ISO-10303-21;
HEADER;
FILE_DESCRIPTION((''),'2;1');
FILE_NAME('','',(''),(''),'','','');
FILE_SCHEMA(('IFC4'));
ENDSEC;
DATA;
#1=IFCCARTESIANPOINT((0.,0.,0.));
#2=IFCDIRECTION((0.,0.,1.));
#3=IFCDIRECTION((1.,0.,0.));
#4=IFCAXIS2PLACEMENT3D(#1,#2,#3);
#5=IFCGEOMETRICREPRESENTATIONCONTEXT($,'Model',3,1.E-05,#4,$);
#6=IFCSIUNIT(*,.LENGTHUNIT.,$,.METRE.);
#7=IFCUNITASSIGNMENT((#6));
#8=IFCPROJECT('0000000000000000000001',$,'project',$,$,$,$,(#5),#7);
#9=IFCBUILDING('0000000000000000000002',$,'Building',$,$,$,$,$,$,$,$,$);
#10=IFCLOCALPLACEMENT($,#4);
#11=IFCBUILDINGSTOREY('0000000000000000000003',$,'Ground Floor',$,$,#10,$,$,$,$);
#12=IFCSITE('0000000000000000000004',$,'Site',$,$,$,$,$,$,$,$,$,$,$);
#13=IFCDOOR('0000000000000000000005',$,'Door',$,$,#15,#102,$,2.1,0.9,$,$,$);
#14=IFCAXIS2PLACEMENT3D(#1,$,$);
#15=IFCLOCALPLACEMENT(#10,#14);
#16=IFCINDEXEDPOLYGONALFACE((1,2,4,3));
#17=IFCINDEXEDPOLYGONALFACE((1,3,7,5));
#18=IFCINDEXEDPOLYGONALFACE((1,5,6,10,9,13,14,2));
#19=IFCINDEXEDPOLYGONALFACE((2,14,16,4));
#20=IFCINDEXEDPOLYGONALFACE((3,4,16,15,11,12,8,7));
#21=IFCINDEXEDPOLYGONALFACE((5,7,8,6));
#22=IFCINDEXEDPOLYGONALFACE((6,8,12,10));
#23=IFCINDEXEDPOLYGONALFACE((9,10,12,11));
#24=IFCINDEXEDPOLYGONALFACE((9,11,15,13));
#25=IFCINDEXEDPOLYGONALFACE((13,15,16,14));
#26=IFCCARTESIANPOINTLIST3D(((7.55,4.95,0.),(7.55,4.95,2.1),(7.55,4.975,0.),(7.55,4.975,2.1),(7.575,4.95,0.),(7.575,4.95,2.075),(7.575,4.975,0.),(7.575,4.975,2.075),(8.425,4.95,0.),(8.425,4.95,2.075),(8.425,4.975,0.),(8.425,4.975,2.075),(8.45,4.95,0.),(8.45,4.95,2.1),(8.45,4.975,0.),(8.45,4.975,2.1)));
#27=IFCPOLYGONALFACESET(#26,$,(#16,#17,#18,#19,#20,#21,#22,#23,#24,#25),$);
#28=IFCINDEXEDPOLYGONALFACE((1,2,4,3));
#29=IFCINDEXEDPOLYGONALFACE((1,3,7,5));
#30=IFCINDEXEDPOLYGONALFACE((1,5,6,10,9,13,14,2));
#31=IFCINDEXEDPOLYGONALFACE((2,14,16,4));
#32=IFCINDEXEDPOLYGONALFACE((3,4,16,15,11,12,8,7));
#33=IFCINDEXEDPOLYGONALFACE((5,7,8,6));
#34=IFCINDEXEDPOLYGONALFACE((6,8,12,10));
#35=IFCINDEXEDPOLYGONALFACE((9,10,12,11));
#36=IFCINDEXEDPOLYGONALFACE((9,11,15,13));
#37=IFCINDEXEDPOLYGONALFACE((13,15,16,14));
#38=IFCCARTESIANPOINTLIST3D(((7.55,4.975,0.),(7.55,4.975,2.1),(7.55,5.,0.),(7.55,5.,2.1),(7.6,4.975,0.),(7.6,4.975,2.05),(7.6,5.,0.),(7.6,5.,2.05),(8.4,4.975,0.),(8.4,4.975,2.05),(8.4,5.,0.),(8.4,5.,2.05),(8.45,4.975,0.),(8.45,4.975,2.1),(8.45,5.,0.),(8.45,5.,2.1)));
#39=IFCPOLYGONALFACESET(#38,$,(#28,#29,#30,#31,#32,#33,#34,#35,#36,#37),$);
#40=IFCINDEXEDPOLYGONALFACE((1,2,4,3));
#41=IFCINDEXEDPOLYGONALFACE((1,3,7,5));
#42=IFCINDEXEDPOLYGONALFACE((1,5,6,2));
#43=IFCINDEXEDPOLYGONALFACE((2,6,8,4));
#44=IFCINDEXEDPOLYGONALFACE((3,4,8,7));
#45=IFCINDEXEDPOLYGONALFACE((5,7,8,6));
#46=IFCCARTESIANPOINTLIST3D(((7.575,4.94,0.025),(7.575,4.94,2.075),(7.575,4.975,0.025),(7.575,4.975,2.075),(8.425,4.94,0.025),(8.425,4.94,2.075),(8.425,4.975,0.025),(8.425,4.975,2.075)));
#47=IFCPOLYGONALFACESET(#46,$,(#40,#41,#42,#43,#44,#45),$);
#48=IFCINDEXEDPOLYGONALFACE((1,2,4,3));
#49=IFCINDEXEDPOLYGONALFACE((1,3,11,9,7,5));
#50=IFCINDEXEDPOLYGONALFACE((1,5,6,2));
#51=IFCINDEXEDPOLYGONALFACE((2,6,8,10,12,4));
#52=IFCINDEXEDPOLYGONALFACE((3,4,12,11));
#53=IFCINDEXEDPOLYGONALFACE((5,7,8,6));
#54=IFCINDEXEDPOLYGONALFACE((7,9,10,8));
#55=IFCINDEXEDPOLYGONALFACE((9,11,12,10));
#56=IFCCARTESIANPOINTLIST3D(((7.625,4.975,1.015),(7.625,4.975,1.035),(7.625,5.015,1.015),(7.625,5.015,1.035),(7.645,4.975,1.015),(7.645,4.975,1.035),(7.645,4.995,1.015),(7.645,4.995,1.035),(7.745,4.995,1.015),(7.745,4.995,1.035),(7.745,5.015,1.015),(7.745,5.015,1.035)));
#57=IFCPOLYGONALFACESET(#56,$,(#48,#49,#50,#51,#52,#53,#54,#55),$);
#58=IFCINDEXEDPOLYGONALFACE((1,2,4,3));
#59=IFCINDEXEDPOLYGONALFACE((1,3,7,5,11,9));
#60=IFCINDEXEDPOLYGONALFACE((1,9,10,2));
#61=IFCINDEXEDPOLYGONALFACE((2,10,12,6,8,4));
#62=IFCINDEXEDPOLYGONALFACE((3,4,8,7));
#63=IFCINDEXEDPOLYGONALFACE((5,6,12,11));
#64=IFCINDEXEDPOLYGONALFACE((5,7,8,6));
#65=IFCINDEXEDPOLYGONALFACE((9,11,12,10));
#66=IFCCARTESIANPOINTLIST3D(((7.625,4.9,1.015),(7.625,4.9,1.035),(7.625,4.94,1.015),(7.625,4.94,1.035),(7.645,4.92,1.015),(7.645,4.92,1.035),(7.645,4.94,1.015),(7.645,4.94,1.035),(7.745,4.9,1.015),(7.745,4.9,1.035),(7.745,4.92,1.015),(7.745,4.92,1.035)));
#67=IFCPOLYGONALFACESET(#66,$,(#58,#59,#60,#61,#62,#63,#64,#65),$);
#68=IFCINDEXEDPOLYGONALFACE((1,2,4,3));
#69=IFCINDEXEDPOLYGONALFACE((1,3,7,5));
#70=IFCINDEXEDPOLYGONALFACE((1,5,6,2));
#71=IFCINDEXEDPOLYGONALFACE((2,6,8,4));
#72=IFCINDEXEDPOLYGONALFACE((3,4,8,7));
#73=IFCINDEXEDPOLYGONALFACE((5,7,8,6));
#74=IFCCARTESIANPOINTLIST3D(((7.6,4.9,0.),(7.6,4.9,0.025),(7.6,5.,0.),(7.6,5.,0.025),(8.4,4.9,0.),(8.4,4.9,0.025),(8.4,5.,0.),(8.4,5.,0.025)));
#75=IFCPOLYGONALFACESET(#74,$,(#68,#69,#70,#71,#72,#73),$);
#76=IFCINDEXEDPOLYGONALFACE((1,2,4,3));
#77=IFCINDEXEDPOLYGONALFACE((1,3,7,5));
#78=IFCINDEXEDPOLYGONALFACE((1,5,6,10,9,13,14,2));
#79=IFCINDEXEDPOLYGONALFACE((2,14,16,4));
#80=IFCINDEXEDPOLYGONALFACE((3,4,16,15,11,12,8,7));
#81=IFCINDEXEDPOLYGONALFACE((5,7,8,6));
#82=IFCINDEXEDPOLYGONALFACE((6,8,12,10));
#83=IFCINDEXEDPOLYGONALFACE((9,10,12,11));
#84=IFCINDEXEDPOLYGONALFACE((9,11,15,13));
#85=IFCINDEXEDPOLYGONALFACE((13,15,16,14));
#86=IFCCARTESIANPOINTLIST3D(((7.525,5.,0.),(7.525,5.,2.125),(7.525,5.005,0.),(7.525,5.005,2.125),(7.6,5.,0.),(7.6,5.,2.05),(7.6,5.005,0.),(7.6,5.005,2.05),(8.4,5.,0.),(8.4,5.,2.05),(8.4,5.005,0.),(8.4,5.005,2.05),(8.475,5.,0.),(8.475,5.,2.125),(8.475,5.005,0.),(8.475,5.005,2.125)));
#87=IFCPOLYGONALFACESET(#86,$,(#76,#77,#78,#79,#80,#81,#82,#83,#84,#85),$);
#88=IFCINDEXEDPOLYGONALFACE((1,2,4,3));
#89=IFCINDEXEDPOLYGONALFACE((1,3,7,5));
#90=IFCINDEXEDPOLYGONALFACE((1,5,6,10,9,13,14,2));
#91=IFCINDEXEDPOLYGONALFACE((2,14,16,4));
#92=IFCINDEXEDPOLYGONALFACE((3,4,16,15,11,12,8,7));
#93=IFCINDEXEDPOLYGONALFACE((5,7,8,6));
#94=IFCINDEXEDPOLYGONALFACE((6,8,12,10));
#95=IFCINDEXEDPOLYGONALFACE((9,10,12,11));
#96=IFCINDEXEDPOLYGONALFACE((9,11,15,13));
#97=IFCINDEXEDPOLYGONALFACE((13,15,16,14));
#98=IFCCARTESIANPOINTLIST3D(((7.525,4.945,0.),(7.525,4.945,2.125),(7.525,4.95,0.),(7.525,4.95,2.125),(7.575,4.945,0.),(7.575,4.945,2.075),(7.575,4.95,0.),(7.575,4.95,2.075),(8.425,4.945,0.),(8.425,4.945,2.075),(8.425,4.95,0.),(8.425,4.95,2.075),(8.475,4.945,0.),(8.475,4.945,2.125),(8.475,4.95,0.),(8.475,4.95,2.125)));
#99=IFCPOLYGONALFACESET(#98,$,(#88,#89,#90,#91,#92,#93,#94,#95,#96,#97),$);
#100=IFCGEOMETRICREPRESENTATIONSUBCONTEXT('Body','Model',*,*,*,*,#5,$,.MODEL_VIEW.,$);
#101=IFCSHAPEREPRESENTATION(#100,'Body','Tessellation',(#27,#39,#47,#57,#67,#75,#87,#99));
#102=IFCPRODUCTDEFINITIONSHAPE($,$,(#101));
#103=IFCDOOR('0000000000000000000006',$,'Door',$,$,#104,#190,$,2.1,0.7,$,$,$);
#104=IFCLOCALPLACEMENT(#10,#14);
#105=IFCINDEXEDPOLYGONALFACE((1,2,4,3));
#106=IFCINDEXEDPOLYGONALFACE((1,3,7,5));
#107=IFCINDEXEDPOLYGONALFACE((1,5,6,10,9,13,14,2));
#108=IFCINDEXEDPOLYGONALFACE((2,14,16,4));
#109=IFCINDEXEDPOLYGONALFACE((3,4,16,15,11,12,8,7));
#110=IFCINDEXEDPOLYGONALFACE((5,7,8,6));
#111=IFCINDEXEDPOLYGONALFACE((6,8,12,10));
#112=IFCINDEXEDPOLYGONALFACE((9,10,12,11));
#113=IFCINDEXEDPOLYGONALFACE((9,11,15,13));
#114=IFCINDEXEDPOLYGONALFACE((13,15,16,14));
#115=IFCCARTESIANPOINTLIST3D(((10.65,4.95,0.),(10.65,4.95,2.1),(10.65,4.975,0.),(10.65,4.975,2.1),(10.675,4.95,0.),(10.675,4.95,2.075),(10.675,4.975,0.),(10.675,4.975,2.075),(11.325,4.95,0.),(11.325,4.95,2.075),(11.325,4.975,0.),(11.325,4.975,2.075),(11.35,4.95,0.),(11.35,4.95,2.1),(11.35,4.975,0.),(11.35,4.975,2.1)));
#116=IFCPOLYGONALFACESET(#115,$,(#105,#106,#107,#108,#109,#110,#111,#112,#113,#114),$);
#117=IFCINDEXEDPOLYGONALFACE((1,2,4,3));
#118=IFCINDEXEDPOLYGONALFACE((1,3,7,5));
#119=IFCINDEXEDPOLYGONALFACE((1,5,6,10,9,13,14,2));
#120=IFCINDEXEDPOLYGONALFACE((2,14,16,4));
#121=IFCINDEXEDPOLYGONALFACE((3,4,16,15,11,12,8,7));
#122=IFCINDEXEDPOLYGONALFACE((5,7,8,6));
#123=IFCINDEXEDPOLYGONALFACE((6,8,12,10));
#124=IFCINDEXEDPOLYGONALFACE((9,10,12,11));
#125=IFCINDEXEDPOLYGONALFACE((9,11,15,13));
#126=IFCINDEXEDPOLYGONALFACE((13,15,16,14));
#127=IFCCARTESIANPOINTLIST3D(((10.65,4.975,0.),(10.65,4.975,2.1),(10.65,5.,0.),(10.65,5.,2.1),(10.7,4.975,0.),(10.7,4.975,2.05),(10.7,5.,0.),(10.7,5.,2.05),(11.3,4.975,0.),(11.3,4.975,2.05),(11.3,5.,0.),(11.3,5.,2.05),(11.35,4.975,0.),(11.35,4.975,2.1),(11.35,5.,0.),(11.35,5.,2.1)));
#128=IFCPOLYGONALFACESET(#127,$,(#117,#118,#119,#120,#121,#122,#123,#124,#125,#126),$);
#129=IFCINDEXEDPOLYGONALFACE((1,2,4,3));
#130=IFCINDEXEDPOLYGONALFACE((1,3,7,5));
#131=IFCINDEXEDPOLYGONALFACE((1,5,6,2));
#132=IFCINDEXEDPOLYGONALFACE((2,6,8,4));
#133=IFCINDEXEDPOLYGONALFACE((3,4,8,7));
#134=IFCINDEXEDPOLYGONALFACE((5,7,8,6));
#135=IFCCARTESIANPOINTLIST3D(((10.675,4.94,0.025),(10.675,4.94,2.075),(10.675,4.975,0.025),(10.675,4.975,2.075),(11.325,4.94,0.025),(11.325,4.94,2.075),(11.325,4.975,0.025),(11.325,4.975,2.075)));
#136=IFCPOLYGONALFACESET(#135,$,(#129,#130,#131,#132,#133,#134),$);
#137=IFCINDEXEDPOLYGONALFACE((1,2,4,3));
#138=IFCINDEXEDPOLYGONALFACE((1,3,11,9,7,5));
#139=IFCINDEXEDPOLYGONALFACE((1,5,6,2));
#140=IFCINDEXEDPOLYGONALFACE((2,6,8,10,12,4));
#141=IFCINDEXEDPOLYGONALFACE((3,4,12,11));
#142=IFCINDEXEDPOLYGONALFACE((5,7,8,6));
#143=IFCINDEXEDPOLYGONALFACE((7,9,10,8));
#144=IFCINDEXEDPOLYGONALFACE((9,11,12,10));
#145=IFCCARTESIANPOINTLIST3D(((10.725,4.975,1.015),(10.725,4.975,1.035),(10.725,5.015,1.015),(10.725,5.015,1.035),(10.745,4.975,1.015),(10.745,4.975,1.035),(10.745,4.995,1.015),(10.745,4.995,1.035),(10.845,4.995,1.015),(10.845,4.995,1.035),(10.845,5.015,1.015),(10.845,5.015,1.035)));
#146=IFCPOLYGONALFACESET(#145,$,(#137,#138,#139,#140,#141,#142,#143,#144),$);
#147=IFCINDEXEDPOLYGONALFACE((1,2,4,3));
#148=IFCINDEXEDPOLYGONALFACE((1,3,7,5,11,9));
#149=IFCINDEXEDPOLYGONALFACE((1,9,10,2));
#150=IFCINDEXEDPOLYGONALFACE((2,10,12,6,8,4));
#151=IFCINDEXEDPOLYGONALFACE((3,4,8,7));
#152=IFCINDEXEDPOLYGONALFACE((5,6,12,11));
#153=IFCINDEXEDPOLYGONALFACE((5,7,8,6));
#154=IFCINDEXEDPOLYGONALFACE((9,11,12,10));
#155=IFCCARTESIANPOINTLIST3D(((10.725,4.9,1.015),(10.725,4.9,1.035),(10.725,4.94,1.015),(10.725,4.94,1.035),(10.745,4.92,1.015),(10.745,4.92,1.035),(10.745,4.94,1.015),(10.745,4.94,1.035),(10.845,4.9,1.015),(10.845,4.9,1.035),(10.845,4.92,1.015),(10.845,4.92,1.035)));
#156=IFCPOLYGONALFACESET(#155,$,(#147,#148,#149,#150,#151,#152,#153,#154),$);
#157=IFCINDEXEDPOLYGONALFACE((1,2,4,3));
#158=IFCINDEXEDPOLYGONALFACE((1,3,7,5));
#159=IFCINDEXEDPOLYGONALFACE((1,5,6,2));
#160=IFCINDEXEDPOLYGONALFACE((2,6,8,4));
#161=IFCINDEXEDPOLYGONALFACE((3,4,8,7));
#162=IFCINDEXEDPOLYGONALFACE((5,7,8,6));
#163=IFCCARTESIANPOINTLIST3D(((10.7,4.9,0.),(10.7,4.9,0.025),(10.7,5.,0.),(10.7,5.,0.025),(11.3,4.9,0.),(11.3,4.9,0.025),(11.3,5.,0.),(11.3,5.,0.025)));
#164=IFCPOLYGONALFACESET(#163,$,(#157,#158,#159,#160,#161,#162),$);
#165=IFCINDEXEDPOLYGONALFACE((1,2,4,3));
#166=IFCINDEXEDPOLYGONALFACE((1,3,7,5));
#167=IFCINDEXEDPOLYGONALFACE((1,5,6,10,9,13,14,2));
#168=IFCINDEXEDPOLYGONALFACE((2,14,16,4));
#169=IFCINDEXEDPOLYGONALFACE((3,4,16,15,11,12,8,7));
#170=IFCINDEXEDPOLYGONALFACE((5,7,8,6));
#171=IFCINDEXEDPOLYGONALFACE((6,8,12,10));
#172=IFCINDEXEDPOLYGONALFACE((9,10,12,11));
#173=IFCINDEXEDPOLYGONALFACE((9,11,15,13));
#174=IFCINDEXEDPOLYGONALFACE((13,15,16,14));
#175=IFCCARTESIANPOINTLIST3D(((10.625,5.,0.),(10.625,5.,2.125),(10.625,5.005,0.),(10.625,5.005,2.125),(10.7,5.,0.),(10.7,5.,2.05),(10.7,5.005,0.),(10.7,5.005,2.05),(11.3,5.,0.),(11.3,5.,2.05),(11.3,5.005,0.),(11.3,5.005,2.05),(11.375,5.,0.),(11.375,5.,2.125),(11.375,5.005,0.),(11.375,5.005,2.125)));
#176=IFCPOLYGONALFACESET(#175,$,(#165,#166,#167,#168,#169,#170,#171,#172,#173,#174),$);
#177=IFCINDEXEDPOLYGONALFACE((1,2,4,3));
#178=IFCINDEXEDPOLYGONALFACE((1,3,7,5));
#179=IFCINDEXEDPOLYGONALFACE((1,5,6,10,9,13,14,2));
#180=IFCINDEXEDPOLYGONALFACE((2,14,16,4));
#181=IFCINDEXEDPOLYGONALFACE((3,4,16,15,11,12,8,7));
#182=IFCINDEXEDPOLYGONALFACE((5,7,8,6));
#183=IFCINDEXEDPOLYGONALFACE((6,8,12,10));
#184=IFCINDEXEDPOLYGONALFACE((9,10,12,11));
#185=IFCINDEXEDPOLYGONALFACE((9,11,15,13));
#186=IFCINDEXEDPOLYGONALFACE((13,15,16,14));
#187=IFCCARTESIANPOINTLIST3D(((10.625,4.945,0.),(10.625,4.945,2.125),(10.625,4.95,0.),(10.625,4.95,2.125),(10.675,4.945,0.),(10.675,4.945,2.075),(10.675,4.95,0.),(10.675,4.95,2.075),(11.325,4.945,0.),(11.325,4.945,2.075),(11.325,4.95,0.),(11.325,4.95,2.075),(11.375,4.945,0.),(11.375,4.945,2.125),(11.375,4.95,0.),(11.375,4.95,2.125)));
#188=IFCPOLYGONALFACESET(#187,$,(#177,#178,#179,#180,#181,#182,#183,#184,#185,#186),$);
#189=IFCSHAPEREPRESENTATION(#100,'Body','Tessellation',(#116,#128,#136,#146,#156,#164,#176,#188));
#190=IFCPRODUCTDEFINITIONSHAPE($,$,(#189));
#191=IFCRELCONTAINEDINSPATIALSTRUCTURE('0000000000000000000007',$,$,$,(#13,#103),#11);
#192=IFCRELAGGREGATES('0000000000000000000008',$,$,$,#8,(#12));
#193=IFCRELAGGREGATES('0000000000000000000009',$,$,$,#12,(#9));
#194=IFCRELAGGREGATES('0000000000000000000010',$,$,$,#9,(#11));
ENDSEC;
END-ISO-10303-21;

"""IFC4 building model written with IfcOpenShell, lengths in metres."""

from ifc_helpers import new_model, si_unit, frame, origin_with_axes, place, context, subcontext, project, spatial, line, indexed_curve, outline, extrude, element, save


model = new_model("IFC4")

# Units and contexts
model_context = context("Model", 3, precision=1e-05, world=origin_with_axes())
body_context = subcontext(model_context, "Body", "Model", "MODEL_VIEW")
ifc_project = project(units=[si_unit("LENGTHUNIT", "METRE")], contexts=[model_context])

# Site, building, storey
site = spatial("IfcSite", under=ifc_project, Name="Site")
building = spatial("IfcBuilding", under=site, Name="Building")
storey_placement = place(None, origin_with_axes())
storey = spatial("IfcBuildingStorey", under=building, at=storey_placement, Name="Ground Floor")

# Doors
door_1_placement = place(storey_placement, frame((8.45, 5.0, 0.0), z_axis=(0.0, 0.0, 1.0), x_axis=(-1.0, 0.0, 0.0)))
element("IfcDoor", 1, at=door_1_placement, inside=storey, Name="Door", OverallHeight=2.1, OverallWidth=0.9, context=body_context, shape_type="SweptSolid", body=[
    extrude(outline(indexed_curve([(0.0, 0.0), (0.0, 2.1), (0.9, 2.1), (0.9, 0.0), (0.875, 0.0), (0.875, 2.075), (0.025, 2.075), (0.025, 0.0)], segments=[line(1, 2, 3, 4, 5, 6, 7, 8, 1)])), frame((0.0, 0.025, 0.0), z_axis=(0.0, -1.0, 0.0), x_axis=(1.0, 0.0, 0.0)), (0.0, 0.0, -1.0), 0.025),
    extrude(outline(indexed_curve([(0.0, 0.0), (0.0, 2.1), (0.9, 2.1), (0.9, 0.0), (0.85, 0.0), (0.85, 2.05), (0.05, 2.05), (0.05, 0.0)], segments=[line(1, 2, 3, 4, 5, 6, 7, 8, 1)])), frame((0.0, 0.0, 0.0), z_axis=(0.0, -1.0, 0.0), x_axis=(1.0, 0.0, 0.0)), (0.0, 0.0, -1.0), 0.025),
    extrude(outline(indexed_curve([(0.0, 0.0), (0.85, 0.0), (0.85, 0.035), (0.0, 0.035)], segments=[line(1, 2, 3, 4, 1)])), frame((0.025, 0.025, 0.025), z_axis=(0.0, 0.0, 1.0), x_axis=(1.0, 0.0, 0.0)), (0.0, 0.0, 1.0), 2.05),
    extrude(outline(indexed_curve([(0.0, 0.0), (0.0, -0.04), (-0.12, -0.04), (-0.12, -0.02), (-0.02, -0.02), (-0.02, 0.0)], segments=[line(1, 2, 3, 4, 5, 6, 1)])), frame((0.825, 0.025, 1.015), z_axis=(0.0, 0.0, 1.0), x_axis=(1.0, 0.0, 0.0)), (0.0, 0.0, 1.0), 0.02),
    extrude(outline(indexed_curve([(0.0, 0.0), (0.0, 0.04), (-0.12, 0.04), (-0.12, 0.02), (-0.02, 0.02), (-0.02, 0.0)], segments=[line(1, 2, 3, 4, 5, 6, 1)])), frame((0.825, 0.06, 1.015), z_axis=(0.0, 0.0, 1.0), x_axis=(1.0, 0.0, 0.0)), (0.0, 0.0, 1.0), 0.02),
    extrude(outline(indexed_curve([(0.0, 0.0), (0.8, 0.0), (0.8, 0.1), (0.0, 0.1)], segments=[line(1, 2, 3, 4, 1)])), frame((0.05, 0.0, 0.0), z_axis=(0.0, 0.0, 1.0), x_axis=(1.0, 0.0, 0.0)), (0.0, 0.0, 1.0), 0.025),
    extrude(outline(indexed_curve([(0.0, 0.0), (0.0, 2.125), (0.95, 2.125), (0.95, 0.0), (0.875, 0.0), (0.875, 2.05), (0.075, 2.05), (0.075, 0.0)], segments=[line(1, 2, 3, 4, 5, 6, 7, 8, 1)])), frame((-0.025, -0.005, 0.0), z_axis=(0.0, -1.0, 0.0), x_axis=(1.0, 0.0, 0.0)), (0.0, 0.0, -1.0), 0.005),
    extrude(outline(indexed_curve([(0.0, 0.0), (0.0, 2.125), (0.95, 2.125), (0.95, 0.0), (0.9, 0.0), (0.9, 2.075), (0.05, 2.075), (0.05, 0.0)], segments=[line(1, 2, 3, 4, 5, 6, 7, 8, 1)])), frame((-0.025, 0.05, 0.0), z_axis=(0.0, -1.0, 0.0), x_axis=(1.0, 0.0, 0.0)), (0.0, 0.0, -1.0), 0.005),
])
door_2_placement = place(storey_placement, frame((11.35, 5.0, 0.0), z_axis=(0.0, 0.0, 1.0), x_axis=(-1.0, 0.0, 0.0)))
element("IfcDoor", 2, at=door_2_placement, inside=storey, Name="Door", OverallHeight=2.1, OverallWidth=0.7, context=body_context, shape_type="SweptSolid", body=[
    extrude(outline(indexed_curve([(0.0, 0.0), (0.0, 2.1), (0.7, 2.1), (0.7, 0.0), (0.675, 0.0), (0.675, 2.075), (0.025, 2.075), (0.025, 0.0)], segments=[line(1, 2, 3, 4, 5, 6, 7, 8, 1)])), frame((0.0, 0.025, 0.0), z_axis=(0.0, -1.0, 0.0), x_axis=(1.0, 0.0, 0.0)), (0.0, 0.0, -1.0), 0.025),
    extrude(outline(indexed_curve([(0.0, 0.0), (0.0, 2.1), (0.7, 2.1), (0.7, 0.0), (0.65, 0.0), (0.65, 2.05), (0.05, 2.05), (0.05, 0.0)], segments=[line(1, 2, 3, 4, 5, 6, 7, 8, 1)])), frame((0.0, 0.0, 0.0), z_axis=(0.0, -1.0, 0.0), x_axis=(1.0, 0.0, 0.0)), (0.0, 0.0, -1.0), 0.025),
    extrude(outline(indexed_curve([(0.0, 0.0), (0.65, 0.0), (0.65, 0.035), (0.0, 0.035)], segments=[line(1, 2, 3, 4, 1)])), frame((0.025, 0.025, 0.025), z_axis=(0.0, 0.0, 1.0), x_axis=(1.0, 0.0, 0.0)), (0.0, 0.0, 1.0), 2.05),
    extrude(outline(indexed_curve([(0.0, 0.0), (0.0, -0.04), (-0.12, -0.04), (-0.12, -0.02), (-0.02, -0.02), (-0.02, 0.0)], segments=[line(1, 2, 3, 4, 5, 6, 1)])), frame((0.625, 0.025, 1.015), z_axis=(0.0, 0.0, 1.0), x_axis=(1.0, 0.0, 0.0)), (0.0, 0.0, 1.0), 0.02),
    extrude(outline(indexed_curve([(0.0, 0.0), (0.0, 0.04), (-0.12, 0.04), (-0.12, 0.02), (-0.02, 0.02), (-0.02, 0.0)], segments=[line(1, 2, 3, 4, 5, 6, 1)])), frame((0.625, 0.06, 1.015), z_axis=(0.0, 0.0, 1.0), x_axis=(1.0, 0.0, 0.0)), (0.0, 0.0, 1.0), 0.02),
    extrude(outline(indexed_curve([(0.0, 0.0), (0.6, 0.0), (0.6, 0.1), (0.0, 0.1)], segments=[line(1, 2, 3, 4, 1)])), frame((0.05, 0.0, 0.0), z_axis=(0.0, 0.0, 1.0), x_axis=(1.0, 0.0, 0.0)), (0.0, 0.0, 1.0), 0.025),
    extrude(outline(indexed_curve([(0.0, 0.0), (0.0, 2.125), (0.75, 2.125), (0.75, 0.0), (0.675, 0.0), (0.675, 2.05), (0.075, 2.05), (0.075, 0.0)], segments=[line(1, 2, 3, 4, 5, 6, 7, 8, 1)])), frame((-0.025, -0.005, 0.0), z_axis=(0.0, -1.0, 0.0), x_axis=(1.0, 0.0, 0.0)), (0.0, 0.0, -1.0), 0.005),
    extrude(outline(indexed_curve([(0.0, 0.0), (0.0, 2.125), (0.75, 2.125), (0.75, 0.0), (0.7, 0.0), (0.7, 2.075), (0.05, 2.075), (0.05, 0.0)], segments=[line(1, 2, 3, 4, 5, 6, 7, 8, 1)])), frame((-0.025, 0.05, 0.0), z_axis=(0.0, -1.0, 0.0), x_axis=(1.0, 0.0, 0.0)), (0.0, 0.0, -1.0), 0.005),
])

save(model, "model.ifc")
